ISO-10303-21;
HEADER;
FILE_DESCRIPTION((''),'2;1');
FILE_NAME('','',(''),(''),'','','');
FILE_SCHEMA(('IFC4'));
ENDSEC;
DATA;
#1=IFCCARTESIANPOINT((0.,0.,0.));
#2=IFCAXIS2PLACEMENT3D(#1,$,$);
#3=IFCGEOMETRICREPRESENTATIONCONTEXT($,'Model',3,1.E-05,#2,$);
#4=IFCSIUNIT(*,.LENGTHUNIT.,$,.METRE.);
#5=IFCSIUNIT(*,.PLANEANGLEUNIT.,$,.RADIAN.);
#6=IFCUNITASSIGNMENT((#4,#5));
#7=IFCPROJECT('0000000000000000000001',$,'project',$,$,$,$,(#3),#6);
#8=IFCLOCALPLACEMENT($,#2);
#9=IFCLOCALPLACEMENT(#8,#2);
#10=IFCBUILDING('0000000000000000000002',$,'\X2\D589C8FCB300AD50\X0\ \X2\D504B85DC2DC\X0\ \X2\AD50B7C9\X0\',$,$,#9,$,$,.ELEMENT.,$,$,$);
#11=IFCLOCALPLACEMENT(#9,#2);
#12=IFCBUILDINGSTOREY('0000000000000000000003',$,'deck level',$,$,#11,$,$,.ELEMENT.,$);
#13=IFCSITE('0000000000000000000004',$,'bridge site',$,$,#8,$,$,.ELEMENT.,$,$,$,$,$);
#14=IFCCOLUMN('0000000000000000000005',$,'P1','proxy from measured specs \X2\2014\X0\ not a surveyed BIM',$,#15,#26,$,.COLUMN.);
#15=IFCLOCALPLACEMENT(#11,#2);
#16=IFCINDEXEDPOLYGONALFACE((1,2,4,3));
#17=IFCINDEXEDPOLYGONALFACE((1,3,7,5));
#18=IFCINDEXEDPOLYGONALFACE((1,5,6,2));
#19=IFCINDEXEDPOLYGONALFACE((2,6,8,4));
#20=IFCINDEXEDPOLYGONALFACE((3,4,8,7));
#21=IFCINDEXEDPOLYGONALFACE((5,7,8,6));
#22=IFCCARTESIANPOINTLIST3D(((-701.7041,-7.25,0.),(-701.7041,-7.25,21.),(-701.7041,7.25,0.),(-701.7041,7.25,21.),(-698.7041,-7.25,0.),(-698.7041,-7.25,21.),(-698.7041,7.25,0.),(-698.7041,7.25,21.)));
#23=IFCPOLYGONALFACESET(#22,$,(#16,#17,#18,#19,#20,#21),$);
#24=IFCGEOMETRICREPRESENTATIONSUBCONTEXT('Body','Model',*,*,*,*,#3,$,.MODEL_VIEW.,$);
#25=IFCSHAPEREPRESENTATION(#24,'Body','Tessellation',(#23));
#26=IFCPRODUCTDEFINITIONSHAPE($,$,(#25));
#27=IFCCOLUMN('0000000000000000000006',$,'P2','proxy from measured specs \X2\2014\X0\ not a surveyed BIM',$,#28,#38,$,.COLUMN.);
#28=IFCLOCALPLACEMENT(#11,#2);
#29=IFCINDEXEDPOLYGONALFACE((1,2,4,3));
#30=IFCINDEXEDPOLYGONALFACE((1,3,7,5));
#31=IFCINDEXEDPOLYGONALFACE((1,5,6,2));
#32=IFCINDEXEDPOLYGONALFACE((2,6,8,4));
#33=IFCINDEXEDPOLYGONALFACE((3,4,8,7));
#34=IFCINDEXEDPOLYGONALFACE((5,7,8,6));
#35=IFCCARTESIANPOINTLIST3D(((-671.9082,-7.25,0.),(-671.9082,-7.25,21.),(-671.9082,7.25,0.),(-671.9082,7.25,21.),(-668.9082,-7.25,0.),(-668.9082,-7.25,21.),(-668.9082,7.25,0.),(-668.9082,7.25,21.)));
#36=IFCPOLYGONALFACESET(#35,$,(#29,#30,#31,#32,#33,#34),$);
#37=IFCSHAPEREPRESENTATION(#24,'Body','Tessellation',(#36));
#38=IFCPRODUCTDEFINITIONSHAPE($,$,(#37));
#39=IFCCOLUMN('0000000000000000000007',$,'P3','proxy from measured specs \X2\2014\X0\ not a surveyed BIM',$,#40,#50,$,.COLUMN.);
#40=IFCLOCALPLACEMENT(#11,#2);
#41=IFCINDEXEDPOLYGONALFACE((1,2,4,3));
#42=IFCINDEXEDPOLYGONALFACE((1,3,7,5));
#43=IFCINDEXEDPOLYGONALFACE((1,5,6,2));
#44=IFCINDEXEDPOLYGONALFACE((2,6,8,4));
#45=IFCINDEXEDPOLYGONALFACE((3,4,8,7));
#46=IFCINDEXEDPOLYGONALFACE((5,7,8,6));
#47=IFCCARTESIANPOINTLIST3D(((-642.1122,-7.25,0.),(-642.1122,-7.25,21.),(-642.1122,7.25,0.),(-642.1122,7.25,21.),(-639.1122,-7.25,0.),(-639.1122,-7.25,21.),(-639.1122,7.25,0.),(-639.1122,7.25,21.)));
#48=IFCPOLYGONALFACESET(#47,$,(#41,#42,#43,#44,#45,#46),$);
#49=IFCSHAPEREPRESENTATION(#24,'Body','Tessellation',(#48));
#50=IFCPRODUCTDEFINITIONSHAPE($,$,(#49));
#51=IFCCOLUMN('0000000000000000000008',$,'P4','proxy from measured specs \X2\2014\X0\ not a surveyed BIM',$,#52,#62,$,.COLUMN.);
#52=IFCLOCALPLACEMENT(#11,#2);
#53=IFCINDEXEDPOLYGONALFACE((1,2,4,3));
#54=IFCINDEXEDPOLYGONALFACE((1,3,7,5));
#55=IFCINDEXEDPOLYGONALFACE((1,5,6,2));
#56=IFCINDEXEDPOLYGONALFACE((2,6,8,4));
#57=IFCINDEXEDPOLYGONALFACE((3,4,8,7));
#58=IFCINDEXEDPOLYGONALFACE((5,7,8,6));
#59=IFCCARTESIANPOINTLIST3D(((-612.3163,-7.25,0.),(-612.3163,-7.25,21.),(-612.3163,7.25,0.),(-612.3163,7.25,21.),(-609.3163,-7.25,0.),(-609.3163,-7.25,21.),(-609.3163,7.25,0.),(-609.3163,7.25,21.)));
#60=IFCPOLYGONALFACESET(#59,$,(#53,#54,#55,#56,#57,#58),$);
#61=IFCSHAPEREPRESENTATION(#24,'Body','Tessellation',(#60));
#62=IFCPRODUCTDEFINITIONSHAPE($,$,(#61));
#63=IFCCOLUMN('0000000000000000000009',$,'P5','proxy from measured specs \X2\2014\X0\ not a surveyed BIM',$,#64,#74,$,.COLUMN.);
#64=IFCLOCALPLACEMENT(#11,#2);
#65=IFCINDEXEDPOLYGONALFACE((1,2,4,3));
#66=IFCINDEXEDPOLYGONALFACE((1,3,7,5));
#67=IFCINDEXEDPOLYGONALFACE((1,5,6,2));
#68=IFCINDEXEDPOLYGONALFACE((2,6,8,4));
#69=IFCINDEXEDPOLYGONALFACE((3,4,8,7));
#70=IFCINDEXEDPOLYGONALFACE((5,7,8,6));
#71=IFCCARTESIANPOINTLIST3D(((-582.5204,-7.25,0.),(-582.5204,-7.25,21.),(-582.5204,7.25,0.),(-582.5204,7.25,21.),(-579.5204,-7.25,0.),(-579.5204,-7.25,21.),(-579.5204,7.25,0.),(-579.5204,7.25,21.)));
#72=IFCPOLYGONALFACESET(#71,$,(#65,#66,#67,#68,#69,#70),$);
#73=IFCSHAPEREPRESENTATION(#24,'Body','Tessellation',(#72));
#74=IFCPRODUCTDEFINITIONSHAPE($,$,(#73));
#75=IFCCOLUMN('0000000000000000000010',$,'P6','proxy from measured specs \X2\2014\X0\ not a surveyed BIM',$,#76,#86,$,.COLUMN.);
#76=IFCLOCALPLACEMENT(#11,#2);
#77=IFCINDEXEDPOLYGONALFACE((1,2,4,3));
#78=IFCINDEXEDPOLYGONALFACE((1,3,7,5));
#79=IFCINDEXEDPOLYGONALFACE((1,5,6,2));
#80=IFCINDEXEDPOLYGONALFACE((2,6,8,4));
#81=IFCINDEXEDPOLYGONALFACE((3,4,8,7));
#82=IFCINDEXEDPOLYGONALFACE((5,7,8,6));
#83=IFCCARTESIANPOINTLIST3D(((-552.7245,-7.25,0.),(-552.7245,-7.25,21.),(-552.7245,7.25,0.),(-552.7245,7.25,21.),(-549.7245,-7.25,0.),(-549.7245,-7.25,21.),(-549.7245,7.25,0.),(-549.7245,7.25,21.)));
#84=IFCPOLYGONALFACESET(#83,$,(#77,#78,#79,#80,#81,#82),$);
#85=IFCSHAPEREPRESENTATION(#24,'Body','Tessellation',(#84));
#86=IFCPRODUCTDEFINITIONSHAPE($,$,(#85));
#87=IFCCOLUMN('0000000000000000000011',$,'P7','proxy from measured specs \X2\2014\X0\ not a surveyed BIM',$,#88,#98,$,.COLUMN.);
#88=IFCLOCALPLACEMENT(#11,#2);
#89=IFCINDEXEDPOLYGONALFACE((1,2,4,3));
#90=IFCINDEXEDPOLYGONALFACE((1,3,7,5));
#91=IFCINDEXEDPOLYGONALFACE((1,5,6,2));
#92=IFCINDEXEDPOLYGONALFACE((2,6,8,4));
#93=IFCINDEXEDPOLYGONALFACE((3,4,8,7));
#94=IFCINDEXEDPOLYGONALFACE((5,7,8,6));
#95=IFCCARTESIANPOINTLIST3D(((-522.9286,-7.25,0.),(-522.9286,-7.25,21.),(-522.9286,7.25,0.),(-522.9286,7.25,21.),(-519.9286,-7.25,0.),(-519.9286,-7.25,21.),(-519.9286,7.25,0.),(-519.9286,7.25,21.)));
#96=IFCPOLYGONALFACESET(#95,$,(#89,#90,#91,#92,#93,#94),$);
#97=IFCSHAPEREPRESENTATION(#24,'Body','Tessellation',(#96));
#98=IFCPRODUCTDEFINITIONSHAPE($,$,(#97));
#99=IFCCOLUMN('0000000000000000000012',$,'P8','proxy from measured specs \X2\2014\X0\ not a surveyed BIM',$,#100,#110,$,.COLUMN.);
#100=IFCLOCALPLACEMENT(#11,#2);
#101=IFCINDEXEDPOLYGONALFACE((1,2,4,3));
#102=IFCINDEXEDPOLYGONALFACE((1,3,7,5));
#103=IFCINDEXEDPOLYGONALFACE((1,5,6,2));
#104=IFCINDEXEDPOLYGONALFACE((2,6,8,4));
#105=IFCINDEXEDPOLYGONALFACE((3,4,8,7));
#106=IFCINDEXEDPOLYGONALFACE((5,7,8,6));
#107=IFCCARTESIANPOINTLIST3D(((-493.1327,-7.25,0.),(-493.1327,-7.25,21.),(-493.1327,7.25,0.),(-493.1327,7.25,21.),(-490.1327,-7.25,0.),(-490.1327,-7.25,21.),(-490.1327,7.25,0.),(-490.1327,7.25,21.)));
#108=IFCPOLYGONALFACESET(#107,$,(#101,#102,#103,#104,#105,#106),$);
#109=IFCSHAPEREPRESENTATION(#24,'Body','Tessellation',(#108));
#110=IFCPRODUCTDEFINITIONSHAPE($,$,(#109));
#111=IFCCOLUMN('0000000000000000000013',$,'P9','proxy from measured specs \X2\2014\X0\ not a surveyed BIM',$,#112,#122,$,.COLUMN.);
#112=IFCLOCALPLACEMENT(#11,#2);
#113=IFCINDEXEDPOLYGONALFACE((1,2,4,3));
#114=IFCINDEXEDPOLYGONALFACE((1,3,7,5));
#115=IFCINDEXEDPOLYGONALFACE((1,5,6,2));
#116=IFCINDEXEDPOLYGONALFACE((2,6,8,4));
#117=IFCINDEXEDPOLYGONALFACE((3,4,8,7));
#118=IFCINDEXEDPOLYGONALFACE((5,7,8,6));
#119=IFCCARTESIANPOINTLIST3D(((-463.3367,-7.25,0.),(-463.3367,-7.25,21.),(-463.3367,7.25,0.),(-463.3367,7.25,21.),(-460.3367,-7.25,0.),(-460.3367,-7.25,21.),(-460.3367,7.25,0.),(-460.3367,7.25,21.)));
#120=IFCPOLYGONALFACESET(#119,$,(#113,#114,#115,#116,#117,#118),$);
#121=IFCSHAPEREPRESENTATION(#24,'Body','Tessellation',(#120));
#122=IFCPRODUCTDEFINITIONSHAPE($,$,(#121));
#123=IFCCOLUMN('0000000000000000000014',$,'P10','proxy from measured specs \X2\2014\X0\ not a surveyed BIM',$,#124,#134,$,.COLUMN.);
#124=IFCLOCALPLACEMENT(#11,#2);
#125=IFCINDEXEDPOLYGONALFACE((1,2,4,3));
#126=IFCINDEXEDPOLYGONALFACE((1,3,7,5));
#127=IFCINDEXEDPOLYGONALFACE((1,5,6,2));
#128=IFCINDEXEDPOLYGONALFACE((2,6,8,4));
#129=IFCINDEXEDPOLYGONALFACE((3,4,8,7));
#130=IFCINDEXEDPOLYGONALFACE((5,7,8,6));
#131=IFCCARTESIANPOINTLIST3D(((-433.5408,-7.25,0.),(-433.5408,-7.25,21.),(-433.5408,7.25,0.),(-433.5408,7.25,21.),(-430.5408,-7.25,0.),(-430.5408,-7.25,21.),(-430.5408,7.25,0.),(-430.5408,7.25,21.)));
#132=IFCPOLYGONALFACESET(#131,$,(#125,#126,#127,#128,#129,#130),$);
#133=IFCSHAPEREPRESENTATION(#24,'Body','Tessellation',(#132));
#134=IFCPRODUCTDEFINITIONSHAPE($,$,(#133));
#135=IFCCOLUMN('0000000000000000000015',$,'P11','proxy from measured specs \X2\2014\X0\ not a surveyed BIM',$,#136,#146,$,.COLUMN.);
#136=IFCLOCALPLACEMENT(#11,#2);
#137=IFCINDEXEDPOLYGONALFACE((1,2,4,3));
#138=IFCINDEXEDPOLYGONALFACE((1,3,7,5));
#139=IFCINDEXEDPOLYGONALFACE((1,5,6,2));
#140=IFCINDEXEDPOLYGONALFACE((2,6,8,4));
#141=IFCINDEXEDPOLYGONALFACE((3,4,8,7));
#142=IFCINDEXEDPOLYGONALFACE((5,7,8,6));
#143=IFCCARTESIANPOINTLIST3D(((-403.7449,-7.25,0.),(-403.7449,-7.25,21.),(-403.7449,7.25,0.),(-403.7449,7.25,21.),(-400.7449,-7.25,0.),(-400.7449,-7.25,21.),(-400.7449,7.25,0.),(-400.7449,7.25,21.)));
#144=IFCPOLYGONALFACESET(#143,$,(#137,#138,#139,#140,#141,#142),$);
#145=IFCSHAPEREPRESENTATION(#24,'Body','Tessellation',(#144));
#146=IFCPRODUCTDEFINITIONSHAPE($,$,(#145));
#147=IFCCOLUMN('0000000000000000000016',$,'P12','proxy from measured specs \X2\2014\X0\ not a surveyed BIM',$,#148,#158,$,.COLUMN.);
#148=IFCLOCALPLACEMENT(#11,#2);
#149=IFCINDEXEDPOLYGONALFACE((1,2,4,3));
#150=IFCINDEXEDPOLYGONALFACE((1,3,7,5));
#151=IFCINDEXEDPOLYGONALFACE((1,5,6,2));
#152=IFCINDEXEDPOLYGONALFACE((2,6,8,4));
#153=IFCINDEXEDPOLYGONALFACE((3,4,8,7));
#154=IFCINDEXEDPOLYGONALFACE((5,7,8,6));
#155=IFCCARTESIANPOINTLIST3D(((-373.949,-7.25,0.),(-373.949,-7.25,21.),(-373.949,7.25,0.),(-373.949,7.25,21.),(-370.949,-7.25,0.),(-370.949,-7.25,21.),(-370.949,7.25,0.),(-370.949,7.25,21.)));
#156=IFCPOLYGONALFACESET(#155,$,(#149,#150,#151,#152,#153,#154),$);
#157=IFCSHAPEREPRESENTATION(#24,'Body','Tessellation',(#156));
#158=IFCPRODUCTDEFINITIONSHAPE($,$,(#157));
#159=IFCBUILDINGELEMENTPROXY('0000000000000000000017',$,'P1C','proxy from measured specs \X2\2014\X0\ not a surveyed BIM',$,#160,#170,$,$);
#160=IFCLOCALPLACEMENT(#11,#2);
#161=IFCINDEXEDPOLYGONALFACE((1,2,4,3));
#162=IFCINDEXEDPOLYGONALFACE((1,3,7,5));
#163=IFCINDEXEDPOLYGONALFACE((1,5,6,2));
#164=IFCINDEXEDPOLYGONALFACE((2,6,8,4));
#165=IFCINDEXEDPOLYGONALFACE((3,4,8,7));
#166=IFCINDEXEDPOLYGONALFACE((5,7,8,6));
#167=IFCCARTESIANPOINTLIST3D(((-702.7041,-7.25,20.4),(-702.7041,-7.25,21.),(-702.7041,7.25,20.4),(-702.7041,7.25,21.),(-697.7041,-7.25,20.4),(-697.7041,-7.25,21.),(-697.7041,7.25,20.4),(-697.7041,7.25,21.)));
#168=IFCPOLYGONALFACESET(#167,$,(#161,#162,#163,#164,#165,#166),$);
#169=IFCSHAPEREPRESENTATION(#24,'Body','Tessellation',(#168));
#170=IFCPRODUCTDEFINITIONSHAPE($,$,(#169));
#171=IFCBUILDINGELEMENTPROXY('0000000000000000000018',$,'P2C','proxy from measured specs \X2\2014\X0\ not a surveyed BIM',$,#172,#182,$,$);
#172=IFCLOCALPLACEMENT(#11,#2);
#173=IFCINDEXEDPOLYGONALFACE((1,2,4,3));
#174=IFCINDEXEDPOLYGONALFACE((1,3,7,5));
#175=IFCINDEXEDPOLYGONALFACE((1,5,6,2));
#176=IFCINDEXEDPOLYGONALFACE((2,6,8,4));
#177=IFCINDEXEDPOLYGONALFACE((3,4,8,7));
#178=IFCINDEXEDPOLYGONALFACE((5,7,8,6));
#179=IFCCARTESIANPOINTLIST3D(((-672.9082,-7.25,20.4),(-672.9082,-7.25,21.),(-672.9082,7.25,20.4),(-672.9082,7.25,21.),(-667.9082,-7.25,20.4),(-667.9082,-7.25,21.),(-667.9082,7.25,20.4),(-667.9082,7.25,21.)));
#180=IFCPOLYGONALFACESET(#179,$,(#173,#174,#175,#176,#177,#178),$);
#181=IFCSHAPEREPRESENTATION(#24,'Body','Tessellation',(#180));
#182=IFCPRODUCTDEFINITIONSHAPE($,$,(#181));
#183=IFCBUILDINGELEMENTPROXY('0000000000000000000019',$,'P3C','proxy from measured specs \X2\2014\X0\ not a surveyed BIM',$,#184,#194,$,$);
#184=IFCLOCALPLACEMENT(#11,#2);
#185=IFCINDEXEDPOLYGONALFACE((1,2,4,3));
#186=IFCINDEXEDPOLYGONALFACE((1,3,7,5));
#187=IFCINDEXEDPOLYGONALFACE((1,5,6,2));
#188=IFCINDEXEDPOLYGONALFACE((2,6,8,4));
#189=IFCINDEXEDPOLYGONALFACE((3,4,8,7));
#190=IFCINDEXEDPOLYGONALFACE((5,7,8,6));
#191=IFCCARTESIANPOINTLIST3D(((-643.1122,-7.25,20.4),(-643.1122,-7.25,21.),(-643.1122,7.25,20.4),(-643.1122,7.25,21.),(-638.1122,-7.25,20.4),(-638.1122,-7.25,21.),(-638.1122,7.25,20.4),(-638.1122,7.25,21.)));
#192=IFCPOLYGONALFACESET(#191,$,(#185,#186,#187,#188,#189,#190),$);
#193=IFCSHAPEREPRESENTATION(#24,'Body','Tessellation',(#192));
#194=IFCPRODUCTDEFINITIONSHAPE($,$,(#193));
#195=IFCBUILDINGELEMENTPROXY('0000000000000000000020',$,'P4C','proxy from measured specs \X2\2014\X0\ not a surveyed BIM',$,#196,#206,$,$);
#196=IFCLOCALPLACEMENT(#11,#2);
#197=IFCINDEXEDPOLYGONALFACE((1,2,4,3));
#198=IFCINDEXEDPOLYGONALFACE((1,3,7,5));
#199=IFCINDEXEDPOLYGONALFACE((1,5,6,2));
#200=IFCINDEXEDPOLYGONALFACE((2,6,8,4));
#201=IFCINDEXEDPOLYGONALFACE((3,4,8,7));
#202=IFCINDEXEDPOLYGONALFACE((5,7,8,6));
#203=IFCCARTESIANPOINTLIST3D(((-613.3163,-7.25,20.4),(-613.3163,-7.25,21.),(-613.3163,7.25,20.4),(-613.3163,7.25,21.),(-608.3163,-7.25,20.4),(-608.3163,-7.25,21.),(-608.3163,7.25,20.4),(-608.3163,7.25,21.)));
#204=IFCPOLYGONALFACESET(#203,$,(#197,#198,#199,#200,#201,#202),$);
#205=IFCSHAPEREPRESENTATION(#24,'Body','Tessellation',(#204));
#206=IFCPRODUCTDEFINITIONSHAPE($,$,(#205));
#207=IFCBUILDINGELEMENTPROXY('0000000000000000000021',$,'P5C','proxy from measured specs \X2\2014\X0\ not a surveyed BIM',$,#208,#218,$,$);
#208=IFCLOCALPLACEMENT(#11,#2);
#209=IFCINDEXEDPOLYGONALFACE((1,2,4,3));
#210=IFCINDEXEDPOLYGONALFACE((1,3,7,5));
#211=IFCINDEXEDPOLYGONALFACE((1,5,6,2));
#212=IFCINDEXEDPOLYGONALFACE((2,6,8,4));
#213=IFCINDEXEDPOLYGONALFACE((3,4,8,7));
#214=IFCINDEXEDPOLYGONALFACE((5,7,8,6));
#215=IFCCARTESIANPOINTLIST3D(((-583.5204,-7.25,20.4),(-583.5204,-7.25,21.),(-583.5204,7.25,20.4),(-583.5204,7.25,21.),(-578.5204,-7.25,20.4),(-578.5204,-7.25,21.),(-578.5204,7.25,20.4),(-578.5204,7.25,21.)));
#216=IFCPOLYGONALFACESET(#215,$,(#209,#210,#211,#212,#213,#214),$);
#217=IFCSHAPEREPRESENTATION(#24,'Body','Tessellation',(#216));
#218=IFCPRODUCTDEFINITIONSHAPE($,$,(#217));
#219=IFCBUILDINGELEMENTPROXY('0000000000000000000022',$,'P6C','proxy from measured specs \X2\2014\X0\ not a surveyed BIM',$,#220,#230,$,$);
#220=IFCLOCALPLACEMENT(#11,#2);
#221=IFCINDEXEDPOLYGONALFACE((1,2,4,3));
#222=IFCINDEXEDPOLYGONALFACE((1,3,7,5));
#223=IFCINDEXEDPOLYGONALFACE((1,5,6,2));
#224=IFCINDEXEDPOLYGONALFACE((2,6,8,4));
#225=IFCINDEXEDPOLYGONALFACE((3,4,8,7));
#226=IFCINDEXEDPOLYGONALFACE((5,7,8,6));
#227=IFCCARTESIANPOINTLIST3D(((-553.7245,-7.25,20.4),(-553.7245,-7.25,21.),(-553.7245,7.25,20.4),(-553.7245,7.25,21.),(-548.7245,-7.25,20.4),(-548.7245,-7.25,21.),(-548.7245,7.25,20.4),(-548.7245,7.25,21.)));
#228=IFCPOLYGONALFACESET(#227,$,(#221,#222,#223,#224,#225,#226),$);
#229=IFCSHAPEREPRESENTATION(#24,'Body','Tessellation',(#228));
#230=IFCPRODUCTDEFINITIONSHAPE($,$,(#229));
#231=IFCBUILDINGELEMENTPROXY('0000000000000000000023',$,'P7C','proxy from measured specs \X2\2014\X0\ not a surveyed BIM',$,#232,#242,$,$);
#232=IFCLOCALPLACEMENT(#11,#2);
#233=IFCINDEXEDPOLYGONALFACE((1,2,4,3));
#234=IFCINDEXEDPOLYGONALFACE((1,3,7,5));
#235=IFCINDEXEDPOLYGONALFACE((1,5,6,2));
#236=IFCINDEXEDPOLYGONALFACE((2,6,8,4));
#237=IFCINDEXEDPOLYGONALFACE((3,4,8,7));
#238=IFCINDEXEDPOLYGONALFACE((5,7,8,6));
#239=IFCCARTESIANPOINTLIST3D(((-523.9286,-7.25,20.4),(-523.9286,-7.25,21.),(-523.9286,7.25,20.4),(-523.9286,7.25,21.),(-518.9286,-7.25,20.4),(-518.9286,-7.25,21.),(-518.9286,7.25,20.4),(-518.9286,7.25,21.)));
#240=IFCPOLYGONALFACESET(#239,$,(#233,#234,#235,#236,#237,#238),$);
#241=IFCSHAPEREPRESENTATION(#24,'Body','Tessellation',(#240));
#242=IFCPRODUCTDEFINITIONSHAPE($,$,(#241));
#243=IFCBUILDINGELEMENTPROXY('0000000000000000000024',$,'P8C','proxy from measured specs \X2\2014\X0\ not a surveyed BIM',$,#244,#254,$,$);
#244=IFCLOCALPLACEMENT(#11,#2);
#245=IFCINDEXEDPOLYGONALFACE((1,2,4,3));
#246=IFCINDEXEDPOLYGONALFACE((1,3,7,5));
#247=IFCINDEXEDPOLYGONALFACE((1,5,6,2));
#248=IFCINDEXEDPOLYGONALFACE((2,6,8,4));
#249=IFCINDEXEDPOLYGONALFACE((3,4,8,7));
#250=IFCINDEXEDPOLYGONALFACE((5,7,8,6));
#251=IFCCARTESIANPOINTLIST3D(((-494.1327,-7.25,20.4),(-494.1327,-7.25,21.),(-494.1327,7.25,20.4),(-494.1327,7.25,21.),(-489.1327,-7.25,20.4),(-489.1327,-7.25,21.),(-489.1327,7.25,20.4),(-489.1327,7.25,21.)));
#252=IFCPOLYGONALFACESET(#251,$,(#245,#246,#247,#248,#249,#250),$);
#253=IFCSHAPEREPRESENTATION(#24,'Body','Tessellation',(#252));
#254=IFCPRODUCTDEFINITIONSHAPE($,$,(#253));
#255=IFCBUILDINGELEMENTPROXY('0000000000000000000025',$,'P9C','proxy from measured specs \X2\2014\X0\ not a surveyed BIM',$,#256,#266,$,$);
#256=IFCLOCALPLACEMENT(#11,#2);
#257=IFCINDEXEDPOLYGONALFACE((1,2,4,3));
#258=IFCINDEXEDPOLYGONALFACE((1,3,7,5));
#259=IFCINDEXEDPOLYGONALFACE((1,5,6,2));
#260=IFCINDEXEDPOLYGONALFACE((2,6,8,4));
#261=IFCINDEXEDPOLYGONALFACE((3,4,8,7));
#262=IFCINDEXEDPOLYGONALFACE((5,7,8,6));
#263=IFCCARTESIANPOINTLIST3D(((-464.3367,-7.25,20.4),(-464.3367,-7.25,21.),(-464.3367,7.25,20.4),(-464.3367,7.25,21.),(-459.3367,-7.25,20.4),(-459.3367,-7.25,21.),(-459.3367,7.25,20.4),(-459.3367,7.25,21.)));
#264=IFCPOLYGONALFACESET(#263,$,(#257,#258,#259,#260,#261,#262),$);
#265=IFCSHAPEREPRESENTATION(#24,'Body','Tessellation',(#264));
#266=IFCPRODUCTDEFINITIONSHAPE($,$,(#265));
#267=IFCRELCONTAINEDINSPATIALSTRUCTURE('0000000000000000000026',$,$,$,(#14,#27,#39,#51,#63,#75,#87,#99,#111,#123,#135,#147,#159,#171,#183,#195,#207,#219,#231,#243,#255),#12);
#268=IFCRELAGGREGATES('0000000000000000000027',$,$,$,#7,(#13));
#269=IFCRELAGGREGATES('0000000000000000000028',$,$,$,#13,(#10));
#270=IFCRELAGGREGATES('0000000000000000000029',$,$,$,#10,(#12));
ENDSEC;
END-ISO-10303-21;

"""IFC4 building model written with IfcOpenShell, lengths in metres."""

from ifc_helpers import new_model, si_unit, frame, origin, origin_2d, place, context, subcontext, project, spatial, rectangle, extrude, element, save


model = new_model("IFC4")

# Units and contexts
model_context = context("Model", 3, precision=1e-05, world=origin())
body_context = subcontext(model_context, "Body", "Model", "MODEL_VIEW")
ifc_project = project(units=[si_unit("LENGTHUNIT", "METRE"), si_unit("PLANEANGLEUNIT", "RADIAN")], contexts=[model_context])

# Site, building, storey
site_placement = place(None, origin())
site = spatial("IfcSite", under=ifc_project, at=site_placement, Name="bridge site", CompositionType="ELEMENT")
building_placement = place(site_placement, origin())
building = spatial("IfcBuilding", under=site, at=building_placement, Name="행주대교 프록시 교량", CompositionType="ELEMENT")
storey_placement = place(building_placement, origin())
storey = spatial("IfcBuildingStorey", under=building, at=storey_placement, Name="deck level", CompositionType="ELEMENT")

# Columns
for number, where, name in (
    (1, (-700.2041, 0.0, 0.0), "P1"),
    (2, (-670.4082, 0.0, 0.0), "P2"),
    (3, (-640.6122, 0.0, 0.0), "P3"),
    (4, (-610.8163, 0.0, 0.0), "P4"),
    (5, (-581.0204, 0.0, 0.0), "P5"),
    (6, (-551.2245, 0.0, 0.0), "P6"),
    (7, (-521.4286, 0.0, 0.0), "P7"),
    (8, (-491.6327, 0.0, 0.0), "P8"),
    (9, (-461.8367, 0.0, 0.0), "P9"),
    (10, (-432.0408, 0.0, 0.0), "P10"),
    (11, (-402.2449, 0.0, 0.0), "P11"),
    (12, (-372.449, 0.0, 0.0), "P12"),
):
    element("IfcColumn", number, at=place(storey_placement, frame(where)), inside=storey, Name=name, Description="proxy from measured specs — not a surveyed BIM", PredefinedType="COLUMN", context=body_context, shape_type="SweptSolid", body=[
        extrude(rectangle(XDim=3.0, YDim=14.5, at=origin_2d()), origin(), (0.0, 0.0, 1.0), 21.0),
    ])

# Building element proxies
for number, where, name in (
    (13, (-700.2041, 0.0, 20.4), "P1C"),
    (14, (-670.4082, 0.0, 20.4), "P2C"),
    (15, (-640.6122, 0.0, 20.4), "P3C"),
    (16, (-610.8163, 0.0, 20.4), "P4C"),
    (17, (-581.0204, 0.0, 20.4), "P5C"),
    (18, (-551.2245, 0.0, 20.4), "P6C"),
    (19, (-521.4286, 0.0, 20.4), "P7C"),
    (20, (-491.6327, 0.0, 20.4), "P8C"),
    (21, (-461.8367, 0.0, 20.4), "P9C"),
):
    element("IfcBuildingElementProxy", number, at=place(storey_placement, frame(where)), inside=storey, Name=name, Description="proxy from measured specs — not a surveyed BIM", context=body_context, shape_type="SweptSolid", body=[
        extrude(rectangle(XDim=5.0, YDim=14.5, at=origin_2d()), origin(), (0.0, 0.0, 1.0), 0.6),
    ])

save(model, "model.ifc")
